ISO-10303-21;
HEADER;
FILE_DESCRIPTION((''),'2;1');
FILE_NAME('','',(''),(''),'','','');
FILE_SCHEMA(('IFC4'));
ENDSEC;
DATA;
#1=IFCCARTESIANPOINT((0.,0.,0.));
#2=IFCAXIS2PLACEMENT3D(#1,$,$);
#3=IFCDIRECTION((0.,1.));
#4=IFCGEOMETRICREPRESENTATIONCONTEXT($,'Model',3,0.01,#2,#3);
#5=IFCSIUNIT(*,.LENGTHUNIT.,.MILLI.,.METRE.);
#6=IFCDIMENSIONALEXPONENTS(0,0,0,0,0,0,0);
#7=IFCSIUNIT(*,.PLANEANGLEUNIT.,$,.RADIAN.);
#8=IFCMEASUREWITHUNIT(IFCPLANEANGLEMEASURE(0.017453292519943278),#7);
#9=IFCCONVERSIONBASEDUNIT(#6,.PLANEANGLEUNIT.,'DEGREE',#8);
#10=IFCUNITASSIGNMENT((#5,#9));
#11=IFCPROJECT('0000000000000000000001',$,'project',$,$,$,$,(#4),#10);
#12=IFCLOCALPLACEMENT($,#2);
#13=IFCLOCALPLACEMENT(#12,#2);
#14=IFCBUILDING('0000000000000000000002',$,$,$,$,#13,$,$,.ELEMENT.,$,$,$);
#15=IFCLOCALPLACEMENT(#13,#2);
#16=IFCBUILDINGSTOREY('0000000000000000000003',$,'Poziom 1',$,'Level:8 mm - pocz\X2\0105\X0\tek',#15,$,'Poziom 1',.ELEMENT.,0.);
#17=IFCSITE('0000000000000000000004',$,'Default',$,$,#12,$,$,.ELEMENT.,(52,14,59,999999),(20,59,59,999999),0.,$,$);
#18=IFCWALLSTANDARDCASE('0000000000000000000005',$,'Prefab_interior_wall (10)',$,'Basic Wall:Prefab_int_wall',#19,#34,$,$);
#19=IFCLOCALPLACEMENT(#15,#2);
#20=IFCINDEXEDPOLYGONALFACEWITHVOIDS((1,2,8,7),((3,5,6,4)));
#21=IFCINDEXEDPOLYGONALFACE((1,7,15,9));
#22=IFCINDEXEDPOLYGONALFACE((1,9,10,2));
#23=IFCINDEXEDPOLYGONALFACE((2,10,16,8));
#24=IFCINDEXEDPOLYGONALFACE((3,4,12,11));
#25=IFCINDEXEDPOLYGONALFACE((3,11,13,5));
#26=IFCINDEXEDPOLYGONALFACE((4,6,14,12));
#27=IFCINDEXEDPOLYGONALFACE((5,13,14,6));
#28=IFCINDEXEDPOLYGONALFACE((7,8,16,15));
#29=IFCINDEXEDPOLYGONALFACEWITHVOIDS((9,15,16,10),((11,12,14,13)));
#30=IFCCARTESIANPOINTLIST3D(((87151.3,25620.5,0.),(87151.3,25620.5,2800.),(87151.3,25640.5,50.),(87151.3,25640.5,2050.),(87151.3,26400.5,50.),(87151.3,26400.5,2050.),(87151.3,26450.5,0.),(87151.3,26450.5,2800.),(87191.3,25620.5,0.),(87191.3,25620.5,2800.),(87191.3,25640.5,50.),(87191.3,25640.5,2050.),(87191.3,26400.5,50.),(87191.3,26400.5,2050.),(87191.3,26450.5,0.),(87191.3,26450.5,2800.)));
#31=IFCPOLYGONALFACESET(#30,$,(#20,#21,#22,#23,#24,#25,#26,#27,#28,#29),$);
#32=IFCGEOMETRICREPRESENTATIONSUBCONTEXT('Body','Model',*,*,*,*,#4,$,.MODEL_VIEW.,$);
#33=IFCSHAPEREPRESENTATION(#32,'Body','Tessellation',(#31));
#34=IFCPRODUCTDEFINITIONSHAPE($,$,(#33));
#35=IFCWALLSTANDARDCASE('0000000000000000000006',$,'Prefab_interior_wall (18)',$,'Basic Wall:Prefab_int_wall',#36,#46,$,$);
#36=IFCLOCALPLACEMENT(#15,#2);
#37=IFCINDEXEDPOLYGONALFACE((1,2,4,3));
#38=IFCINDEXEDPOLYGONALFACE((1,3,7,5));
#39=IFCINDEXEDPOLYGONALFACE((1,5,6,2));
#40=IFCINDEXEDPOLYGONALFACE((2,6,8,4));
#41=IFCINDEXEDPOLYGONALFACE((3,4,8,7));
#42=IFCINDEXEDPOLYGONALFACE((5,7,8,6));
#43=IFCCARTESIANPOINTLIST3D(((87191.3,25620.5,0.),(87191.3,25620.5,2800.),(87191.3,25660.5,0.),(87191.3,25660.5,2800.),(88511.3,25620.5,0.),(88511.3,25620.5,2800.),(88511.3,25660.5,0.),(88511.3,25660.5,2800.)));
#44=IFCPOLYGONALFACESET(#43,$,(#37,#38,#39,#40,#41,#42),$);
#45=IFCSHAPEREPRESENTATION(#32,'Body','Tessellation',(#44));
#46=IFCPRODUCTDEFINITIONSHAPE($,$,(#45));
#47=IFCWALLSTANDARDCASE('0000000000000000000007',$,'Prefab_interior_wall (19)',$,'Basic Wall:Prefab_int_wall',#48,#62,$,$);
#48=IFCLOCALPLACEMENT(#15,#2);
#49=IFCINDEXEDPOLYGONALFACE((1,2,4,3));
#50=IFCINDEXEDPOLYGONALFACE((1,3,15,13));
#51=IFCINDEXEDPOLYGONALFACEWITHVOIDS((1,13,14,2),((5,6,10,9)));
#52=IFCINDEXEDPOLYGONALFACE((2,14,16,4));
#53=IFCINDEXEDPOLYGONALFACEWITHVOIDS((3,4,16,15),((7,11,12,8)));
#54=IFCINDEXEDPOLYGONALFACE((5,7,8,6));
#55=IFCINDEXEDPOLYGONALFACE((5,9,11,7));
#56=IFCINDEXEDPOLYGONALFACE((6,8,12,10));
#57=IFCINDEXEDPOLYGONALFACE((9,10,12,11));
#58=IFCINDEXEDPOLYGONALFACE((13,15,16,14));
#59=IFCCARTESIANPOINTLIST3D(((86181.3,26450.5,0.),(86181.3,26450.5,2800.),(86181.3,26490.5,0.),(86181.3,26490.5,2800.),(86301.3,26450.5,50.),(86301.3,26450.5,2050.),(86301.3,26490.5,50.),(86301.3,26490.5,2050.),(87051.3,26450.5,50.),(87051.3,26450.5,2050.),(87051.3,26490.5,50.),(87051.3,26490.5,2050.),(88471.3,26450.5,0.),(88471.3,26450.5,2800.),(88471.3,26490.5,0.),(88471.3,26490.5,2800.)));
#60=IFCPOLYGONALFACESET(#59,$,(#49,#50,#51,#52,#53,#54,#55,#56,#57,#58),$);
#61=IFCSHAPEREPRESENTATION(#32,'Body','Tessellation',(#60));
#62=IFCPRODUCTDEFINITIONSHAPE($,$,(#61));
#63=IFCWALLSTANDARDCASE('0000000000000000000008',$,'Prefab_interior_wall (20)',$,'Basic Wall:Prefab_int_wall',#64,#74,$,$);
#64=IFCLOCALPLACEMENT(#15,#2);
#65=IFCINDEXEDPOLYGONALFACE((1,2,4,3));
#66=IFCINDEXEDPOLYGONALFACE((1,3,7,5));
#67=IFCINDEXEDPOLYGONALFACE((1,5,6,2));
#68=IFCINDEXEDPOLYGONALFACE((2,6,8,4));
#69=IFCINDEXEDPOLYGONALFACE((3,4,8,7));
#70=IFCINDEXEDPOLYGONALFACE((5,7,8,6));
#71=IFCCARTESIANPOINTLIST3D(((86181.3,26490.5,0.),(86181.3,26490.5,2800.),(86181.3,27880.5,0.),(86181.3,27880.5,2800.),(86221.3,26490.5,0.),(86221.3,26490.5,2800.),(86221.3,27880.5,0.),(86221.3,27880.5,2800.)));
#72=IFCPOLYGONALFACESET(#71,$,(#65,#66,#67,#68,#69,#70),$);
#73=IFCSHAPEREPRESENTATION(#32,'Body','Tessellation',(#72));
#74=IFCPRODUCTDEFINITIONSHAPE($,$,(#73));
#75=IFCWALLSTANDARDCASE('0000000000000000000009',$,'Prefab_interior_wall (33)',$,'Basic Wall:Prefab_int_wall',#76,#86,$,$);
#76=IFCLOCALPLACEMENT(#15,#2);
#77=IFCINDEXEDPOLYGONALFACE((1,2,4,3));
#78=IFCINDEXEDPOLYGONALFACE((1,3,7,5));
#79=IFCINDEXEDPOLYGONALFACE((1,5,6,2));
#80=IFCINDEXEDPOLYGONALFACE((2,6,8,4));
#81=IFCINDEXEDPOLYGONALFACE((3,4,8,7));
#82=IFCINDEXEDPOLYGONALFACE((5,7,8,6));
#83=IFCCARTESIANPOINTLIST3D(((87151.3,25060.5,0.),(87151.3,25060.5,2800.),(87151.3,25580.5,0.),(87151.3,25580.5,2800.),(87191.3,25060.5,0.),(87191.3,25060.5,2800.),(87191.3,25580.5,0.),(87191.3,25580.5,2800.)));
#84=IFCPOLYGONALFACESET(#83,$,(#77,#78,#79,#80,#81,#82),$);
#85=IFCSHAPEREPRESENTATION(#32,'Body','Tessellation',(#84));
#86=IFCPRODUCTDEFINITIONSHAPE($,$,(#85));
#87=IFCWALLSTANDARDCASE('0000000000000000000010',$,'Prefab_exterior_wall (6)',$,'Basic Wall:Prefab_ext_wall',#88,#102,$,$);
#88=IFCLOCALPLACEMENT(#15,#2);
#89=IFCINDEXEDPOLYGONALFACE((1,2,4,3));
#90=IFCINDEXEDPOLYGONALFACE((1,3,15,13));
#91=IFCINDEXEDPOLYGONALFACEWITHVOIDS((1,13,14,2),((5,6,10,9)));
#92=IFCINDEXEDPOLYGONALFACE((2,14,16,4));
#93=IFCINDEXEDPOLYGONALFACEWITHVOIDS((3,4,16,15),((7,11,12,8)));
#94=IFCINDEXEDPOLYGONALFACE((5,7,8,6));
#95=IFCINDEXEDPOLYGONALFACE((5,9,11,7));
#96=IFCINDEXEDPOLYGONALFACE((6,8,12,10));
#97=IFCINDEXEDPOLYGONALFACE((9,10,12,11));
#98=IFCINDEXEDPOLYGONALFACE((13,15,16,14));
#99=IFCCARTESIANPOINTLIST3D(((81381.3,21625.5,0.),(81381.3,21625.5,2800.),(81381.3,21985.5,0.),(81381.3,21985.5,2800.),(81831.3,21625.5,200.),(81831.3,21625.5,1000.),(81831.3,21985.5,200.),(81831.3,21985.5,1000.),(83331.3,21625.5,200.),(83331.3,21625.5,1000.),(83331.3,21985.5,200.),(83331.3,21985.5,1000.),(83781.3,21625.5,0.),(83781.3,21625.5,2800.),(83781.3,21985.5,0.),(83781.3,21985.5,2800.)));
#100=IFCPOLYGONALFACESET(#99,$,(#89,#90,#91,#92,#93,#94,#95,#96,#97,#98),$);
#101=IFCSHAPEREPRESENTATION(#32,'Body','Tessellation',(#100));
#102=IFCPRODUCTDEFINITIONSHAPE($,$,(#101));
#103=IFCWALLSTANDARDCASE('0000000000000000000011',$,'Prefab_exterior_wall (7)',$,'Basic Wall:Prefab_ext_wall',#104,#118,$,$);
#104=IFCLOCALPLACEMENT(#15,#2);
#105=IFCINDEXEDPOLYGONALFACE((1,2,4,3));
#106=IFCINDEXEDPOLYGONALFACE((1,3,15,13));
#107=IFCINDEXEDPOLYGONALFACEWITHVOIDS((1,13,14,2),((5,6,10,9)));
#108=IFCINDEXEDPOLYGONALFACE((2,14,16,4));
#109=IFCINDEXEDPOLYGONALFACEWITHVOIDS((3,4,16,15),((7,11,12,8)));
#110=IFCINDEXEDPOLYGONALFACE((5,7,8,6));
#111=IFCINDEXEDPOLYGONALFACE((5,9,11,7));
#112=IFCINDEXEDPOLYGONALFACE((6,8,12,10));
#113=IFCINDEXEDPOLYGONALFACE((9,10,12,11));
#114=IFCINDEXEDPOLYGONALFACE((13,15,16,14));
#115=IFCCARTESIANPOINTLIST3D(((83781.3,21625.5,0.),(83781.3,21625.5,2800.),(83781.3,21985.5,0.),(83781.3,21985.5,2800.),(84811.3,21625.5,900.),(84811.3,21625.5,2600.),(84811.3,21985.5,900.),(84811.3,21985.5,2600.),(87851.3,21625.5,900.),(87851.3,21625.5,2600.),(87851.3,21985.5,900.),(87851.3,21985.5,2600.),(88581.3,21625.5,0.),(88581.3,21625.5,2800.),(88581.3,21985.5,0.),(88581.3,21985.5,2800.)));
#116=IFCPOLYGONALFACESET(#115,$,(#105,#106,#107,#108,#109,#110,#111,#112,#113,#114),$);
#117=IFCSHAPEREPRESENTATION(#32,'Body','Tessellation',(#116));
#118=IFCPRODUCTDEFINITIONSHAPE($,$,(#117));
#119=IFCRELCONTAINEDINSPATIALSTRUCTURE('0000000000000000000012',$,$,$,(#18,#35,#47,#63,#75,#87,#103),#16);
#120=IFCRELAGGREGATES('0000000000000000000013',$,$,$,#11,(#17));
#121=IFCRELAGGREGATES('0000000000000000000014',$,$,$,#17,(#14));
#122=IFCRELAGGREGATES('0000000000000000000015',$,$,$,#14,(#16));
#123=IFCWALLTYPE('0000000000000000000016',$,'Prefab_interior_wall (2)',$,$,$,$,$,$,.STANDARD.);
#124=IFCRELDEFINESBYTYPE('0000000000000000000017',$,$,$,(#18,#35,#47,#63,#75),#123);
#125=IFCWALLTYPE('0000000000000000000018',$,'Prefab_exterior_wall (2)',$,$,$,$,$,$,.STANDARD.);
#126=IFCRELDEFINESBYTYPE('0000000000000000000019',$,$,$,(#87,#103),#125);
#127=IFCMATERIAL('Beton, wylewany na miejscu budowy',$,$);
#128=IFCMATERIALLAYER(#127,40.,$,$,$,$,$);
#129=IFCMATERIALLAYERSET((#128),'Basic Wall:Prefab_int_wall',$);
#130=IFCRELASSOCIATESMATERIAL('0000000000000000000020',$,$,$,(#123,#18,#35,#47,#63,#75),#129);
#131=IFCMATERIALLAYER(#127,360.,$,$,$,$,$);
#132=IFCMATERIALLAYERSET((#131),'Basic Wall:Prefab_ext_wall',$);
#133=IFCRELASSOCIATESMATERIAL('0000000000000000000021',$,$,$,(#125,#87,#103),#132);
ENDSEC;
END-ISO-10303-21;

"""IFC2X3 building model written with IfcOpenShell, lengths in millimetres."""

from ifc_helpers import new_model, entity, si_unit, converted_unit, direction, frame, frame_2d, origin, origin_2d_with_axis, place, context, subcontext, project, spatial, rectangle, extrude, material, layer, layer_set, layer_usage, type_object, element, save


model = new_model("IFC2X3")

# Units and contexts
model_context = context("Model", 3, precision=0.01, world=origin(), true_north=direction((0.0, 1.0)))
body_context = subcontext(model_context, "Body", "Model", "MODEL_VIEW")
ifc_project = project(units=[si_unit("LENGTHUNIT", "METRE", prefix="MILLI"), converted_unit("PLANEANGLEUNIT", "DEGREE", entity("IfcPlaneAngleMeasure", 0.017453292519943278), si_unit("PLANEANGLEUNIT", "RADIAN"), dimensions=[0, 0, 0, 0, 0, 0, 0])], contexts=[model_context])

# Site, building, storey
site_placement = place(None, origin())
site = spatial("IfcSite", under=ifc_project, at=site_placement, Name="Default", CompositionType="ELEMENT", RefLatitude=(52, 14, 59, 999999), RefLongitude=(20, 59, 59, 999999), RefElevation=0.0)
building_placement = place(site_placement, origin())
building = spatial("IfcBuilding", under=site, at=building_placement, CompositionType="ELEMENT")
storey_placement = place(building_placement, origin())
storey = spatial("IfcBuildingStorey", under=building, at=storey_placement, Name="Poziom 1", ObjectType="Level:8 mm - początek", LongName="Poziom 1", CompositionType="ELEMENT", Elevation=0.0)

# Shared definitions
ifc_material = material(Name="Beton, wylewany na miejscu budowy")

# Shared definitions
ifc_layer_1 = layer(ifc_material, 40.0)
ifc_layer_set_1 = layer_set([ifc_layer_1], Name="Basic Wall:Prefab_int_wall")
wall_type_1 = type_object("IfcWallType", Name="Prefab_interior_wall (2)", PredefinedType="STANDARD", material=ifc_layer_set_1)

# Wall, opening
ifc_layer_usage_1 = layer_usage(ifc_layer_set_1, "AXIS2", "NEGATIVE", 20.0)
wall_1_placement = place(storey_placement, frame((87171.3, 25620.5, 0.0), z_axis=(0.0, 0.0, 1.0), x_axis=(0.0, 1.0, 0.0)))
wall_1 = element("IfcWallStandardCase", 1, at=wall_1_placement, inside=storey, type_object=wall_type_1, material=ifc_layer_usage_1, Name="Prefab_interior_wall (10)", ObjectType="Basic Wall:Prefab_int_wall", context=body_context, shape_type="SweptSolid", body=[
    extrude(rectangle(XDim=830.0, YDim=40.0, at=frame_2d((415.0, 0.0), x_axis=(-1.0, 0.0))), origin(), (0.0, 0.0, 1.0), 2800.0),
])
opening_1_placement = place(wall_1_placement, origin())
element("IfcOpeningElement", 2, at=opening_1_placement, cuts=wall_1, ObjectType="Opening", context=body_context, shape_type="SweptSolid", body=[
    extrude(rectangle(XDim=2000.0, YDim=760.0, at=frame_2d((0.0, 0.0), x_axis=(0.0, 1.0))), frame((400.0, 20.0, 1050.0), z_axis=(0.0, -1.0, 0.0), x_axis=(-1.0, 0.0, 0.0)), (0.0, 0.0, 1.0), 40.0),
])

# Wall
ifc_layer_usage_2 = layer_usage(ifc_layer_set_1, "AXIS2", "NEGATIVE", 20.0)
wall_2_placement = place(storey_placement, frame((88511.3, 25640.5, 0.0), z_axis=(0.0, 0.0, 1.0), x_axis=(-1.0, 0.0, 0.0)))
element("IfcWallStandardCase", 3, at=wall_2_placement, inside=storey, type_object=wall_type_1, material=ifc_layer_usage_2, Name="Prefab_interior_wall (18)", ObjectType="Basic Wall:Prefab_int_wall", context=body_context, shape_type="SweptSolid", body=[
    extrude(rectangle(XDim=1320.0, YDim=40.0, at=frame_2d((660.0, 0.0), x_axis=(-1.0, 0.0))), origin(), (0.0, 0.0, 1.0), 2800.0),
])

# Wall, opening
ifc_layer_usage_3 = layer_usage(ifc_layer_set_1, "AXIS2", "NEGATIVE", 20.0)
wall_3_placement = place(storey_placement, frame((88471.3, 26470.5, 0.0), z_axis=(0.0, 0.0, 1.0), x_axis=(-1.0, 0.0, 0.0)))
wall_3 = element("IfcWallStandardCase", 4, at=wall_3_placement, inside=storey, type_object=wall_type_1, material=ifc_layer_usage_3, Name="Prefab_interior_wall (19)", ObjectType="Basic Wall:Prefab_int_wall", context=body_context, shape_type="SweptSolid", body=[
    extrude(rectangle(XDim=2290.0, YDim=40.0, at=frame_2d((1145.0, 0.0), x_axis=(-1.0, 0.0))), origin(), (0.0, 0.0, 1.0), 2800.0),
])
opening_2_placement = place(wall_3_placement, origin())
element("IfcOpeningElement", 5, at=opening_2_placement, cuts=wall_3, ObjectType="Opening", context=body_context, shape_type="SweptSolid", body=[
    extrude(rectangle(XDim=2000.0, YDim=750.0, at=frame_2d((0.0, 0.0), x_axis=(0.0, 1.0))), frame((1795.0, 20.0, 1050.0), z_axis=(0.0, -1.0, 0.0), x_axis=(-1.0, 0.0, 0.0)), (0.0, 0.0, 1.0), 40.0),
])

# Walls
ifc_layer_usage_4 = layer_usage(ifc_layer_set_1, "AXIS2", "NEGATIVE", 20.0)
wall_4_placement = place(storey_placement, frame((86201.3, 26490.5, 0.0), z_axis=(0.0, 0.0, 1.0), x_axis=(0.0, 1.0, 0.0)))
element("IfcWallStandardCase", 6, at=wall_4_placement, inside=storey, type_object=wall_type_1, material=ifc_layer_usage_4, Name="Prefab_interior_wall (20)", ObjectType="Basic Wall:Prefab_int_wall", context=body_context, shape_type="SweptSolid", body=[
    extrude(rectangle(XDim=1390.0, YDim=40.0, at=frame_2d((695.0, 0.0), x_axis=(-1.0, 0.0))), origin(), (0.0, 0.0, 1.0), 2800.0),
])
ifc_layer_usage_5 = layer_usage(ifc_layer_set_1, "AXIS2", "NEGATIVE", 20.0)
wall_5_placement = place(storey_placement, frame((87171.3, 25580.5, 0.0), z_axis=(0.0, 0.0, 1.0), x_axis=(0.0, -1.0, 0.0)))
element("IfcWallStandardCase", 7, at=wall_5_placement, inside=storey, type_object=wall_type_1, material=ifc_layer_usage_5, Name="Prefab_interior_wall (33)", ObjectType="Basic Wall:Prefab_int_wall", context=body_context, shape_type="SweptSolid", body=[
    extrude(rectangle(XDim=520.0, YDim=40.0, at=frame_2d((260.0, 0.0), x_axis=(-1.0, 0.0))), origin(), (0.0, 0.0, 1.0), 2800.0),
])

# Walls, openings
ifc_layer_2 = layer(ifc_material, 360.0)
ifc_layer_set_2 = layer_set([ifc_layer_2], Name="Basic Wall:Prefab_ext_wall")
ifc_layer_usage_6 = layer_usage(ifc_layer_set_2, "AXIS2", "NEGATIVE", 180.0)
wall_type_2 = type_object("IfcWallType", Name="Prefab_exterior_wall (2)", PredefinedType="STANDARD", material=ifc_layer_set_2)
wall_6_placement = place(storey_placement, frame((81381.3, 21805.5, 0.0)))
wall_6 = element("IfcWallStandardCase", 8, at=wall_6_placement, inside=storey, type_object=wall_type_2, material=ifc_layer_usage_6, Name="Prefab_exterior_wall (6)", ObjectType="Basic Wall:Prefab_ext_wall", context=body_context, shape_type="SweptSolid", body=[
    extrude(rectangle(XDim=2400.0, YDim=360.0, at=frame_2d((1200.0, 0.0), x_axis=(-1.0, 0.0))), origin(), (0.0, 0.0, 1.0), 2800.0),
])
opening_3_placement = place(wall_6_placement, origin())
element("IfcOpeningElement", 9, at=opening_3_placement, cuts=wall_6, ObjectType="Opening", context=body_context, shape_type="SweptSolid", body=[
    extrude(rectangle(XDim=800.0, YDim=1500.0, at=frame_2d((0.0, 0.0), x_axis=(0.0, 1.0))), frame((1200.0, 180.0, 600.0), z_axis=(0.0, -1.0, 0.0), x_axis=(-1.0, 0.0, 0.0)), (0.0, 0.0, 1.0), 360.0),
])
ifc_layer_usage_7 = layer_usage(ifc_layer_set_2, "AXIS2", "NEGATIVE", 180.0)
wall_7_placement = place(storey_placement, frame((83781.3, 21805.5, 0.0)))
wall_7 = element("IfcWallStandardCase", 10, at=wall_7_placement, inside=storey, type_object=wall_type_2, material=ifc_layer_usage_7, Name="Prefab_exterior_wall (7)", ObjectType="Basic Wall:Prefab_ext_wall", context=body_context, shape_type="SweptSolid", body=[
    extrude(rectangle(XDim=4800.0, YDim=360.0, at=frame_2d((2400.0, 0.0), x_axis=(-1.0, 0.0))), origin(), (0.0, 0.0, 1.0), 2800.0),
])
opening_4_placement = place(wall_7_placement, origin())
element("IfcOpeningElement", 11, at=opening_4_placement, cuts=wall_7, ObjectType="Opening", context=body_context, shape_type="SweptSolid", body=[
    extrude(rectangle(XDim=1700.0, YDim=3040.0, at=origin_2d_with_axis()), frame((2550.0, 180.0, 1750.0), z_axis=(0.0, -1.0, 0.0), x_axis=(0.0, 0.0, 1.0)), (0.0, 0.0, 1.0), 360.0),
])

save(model, "model.ifc")
